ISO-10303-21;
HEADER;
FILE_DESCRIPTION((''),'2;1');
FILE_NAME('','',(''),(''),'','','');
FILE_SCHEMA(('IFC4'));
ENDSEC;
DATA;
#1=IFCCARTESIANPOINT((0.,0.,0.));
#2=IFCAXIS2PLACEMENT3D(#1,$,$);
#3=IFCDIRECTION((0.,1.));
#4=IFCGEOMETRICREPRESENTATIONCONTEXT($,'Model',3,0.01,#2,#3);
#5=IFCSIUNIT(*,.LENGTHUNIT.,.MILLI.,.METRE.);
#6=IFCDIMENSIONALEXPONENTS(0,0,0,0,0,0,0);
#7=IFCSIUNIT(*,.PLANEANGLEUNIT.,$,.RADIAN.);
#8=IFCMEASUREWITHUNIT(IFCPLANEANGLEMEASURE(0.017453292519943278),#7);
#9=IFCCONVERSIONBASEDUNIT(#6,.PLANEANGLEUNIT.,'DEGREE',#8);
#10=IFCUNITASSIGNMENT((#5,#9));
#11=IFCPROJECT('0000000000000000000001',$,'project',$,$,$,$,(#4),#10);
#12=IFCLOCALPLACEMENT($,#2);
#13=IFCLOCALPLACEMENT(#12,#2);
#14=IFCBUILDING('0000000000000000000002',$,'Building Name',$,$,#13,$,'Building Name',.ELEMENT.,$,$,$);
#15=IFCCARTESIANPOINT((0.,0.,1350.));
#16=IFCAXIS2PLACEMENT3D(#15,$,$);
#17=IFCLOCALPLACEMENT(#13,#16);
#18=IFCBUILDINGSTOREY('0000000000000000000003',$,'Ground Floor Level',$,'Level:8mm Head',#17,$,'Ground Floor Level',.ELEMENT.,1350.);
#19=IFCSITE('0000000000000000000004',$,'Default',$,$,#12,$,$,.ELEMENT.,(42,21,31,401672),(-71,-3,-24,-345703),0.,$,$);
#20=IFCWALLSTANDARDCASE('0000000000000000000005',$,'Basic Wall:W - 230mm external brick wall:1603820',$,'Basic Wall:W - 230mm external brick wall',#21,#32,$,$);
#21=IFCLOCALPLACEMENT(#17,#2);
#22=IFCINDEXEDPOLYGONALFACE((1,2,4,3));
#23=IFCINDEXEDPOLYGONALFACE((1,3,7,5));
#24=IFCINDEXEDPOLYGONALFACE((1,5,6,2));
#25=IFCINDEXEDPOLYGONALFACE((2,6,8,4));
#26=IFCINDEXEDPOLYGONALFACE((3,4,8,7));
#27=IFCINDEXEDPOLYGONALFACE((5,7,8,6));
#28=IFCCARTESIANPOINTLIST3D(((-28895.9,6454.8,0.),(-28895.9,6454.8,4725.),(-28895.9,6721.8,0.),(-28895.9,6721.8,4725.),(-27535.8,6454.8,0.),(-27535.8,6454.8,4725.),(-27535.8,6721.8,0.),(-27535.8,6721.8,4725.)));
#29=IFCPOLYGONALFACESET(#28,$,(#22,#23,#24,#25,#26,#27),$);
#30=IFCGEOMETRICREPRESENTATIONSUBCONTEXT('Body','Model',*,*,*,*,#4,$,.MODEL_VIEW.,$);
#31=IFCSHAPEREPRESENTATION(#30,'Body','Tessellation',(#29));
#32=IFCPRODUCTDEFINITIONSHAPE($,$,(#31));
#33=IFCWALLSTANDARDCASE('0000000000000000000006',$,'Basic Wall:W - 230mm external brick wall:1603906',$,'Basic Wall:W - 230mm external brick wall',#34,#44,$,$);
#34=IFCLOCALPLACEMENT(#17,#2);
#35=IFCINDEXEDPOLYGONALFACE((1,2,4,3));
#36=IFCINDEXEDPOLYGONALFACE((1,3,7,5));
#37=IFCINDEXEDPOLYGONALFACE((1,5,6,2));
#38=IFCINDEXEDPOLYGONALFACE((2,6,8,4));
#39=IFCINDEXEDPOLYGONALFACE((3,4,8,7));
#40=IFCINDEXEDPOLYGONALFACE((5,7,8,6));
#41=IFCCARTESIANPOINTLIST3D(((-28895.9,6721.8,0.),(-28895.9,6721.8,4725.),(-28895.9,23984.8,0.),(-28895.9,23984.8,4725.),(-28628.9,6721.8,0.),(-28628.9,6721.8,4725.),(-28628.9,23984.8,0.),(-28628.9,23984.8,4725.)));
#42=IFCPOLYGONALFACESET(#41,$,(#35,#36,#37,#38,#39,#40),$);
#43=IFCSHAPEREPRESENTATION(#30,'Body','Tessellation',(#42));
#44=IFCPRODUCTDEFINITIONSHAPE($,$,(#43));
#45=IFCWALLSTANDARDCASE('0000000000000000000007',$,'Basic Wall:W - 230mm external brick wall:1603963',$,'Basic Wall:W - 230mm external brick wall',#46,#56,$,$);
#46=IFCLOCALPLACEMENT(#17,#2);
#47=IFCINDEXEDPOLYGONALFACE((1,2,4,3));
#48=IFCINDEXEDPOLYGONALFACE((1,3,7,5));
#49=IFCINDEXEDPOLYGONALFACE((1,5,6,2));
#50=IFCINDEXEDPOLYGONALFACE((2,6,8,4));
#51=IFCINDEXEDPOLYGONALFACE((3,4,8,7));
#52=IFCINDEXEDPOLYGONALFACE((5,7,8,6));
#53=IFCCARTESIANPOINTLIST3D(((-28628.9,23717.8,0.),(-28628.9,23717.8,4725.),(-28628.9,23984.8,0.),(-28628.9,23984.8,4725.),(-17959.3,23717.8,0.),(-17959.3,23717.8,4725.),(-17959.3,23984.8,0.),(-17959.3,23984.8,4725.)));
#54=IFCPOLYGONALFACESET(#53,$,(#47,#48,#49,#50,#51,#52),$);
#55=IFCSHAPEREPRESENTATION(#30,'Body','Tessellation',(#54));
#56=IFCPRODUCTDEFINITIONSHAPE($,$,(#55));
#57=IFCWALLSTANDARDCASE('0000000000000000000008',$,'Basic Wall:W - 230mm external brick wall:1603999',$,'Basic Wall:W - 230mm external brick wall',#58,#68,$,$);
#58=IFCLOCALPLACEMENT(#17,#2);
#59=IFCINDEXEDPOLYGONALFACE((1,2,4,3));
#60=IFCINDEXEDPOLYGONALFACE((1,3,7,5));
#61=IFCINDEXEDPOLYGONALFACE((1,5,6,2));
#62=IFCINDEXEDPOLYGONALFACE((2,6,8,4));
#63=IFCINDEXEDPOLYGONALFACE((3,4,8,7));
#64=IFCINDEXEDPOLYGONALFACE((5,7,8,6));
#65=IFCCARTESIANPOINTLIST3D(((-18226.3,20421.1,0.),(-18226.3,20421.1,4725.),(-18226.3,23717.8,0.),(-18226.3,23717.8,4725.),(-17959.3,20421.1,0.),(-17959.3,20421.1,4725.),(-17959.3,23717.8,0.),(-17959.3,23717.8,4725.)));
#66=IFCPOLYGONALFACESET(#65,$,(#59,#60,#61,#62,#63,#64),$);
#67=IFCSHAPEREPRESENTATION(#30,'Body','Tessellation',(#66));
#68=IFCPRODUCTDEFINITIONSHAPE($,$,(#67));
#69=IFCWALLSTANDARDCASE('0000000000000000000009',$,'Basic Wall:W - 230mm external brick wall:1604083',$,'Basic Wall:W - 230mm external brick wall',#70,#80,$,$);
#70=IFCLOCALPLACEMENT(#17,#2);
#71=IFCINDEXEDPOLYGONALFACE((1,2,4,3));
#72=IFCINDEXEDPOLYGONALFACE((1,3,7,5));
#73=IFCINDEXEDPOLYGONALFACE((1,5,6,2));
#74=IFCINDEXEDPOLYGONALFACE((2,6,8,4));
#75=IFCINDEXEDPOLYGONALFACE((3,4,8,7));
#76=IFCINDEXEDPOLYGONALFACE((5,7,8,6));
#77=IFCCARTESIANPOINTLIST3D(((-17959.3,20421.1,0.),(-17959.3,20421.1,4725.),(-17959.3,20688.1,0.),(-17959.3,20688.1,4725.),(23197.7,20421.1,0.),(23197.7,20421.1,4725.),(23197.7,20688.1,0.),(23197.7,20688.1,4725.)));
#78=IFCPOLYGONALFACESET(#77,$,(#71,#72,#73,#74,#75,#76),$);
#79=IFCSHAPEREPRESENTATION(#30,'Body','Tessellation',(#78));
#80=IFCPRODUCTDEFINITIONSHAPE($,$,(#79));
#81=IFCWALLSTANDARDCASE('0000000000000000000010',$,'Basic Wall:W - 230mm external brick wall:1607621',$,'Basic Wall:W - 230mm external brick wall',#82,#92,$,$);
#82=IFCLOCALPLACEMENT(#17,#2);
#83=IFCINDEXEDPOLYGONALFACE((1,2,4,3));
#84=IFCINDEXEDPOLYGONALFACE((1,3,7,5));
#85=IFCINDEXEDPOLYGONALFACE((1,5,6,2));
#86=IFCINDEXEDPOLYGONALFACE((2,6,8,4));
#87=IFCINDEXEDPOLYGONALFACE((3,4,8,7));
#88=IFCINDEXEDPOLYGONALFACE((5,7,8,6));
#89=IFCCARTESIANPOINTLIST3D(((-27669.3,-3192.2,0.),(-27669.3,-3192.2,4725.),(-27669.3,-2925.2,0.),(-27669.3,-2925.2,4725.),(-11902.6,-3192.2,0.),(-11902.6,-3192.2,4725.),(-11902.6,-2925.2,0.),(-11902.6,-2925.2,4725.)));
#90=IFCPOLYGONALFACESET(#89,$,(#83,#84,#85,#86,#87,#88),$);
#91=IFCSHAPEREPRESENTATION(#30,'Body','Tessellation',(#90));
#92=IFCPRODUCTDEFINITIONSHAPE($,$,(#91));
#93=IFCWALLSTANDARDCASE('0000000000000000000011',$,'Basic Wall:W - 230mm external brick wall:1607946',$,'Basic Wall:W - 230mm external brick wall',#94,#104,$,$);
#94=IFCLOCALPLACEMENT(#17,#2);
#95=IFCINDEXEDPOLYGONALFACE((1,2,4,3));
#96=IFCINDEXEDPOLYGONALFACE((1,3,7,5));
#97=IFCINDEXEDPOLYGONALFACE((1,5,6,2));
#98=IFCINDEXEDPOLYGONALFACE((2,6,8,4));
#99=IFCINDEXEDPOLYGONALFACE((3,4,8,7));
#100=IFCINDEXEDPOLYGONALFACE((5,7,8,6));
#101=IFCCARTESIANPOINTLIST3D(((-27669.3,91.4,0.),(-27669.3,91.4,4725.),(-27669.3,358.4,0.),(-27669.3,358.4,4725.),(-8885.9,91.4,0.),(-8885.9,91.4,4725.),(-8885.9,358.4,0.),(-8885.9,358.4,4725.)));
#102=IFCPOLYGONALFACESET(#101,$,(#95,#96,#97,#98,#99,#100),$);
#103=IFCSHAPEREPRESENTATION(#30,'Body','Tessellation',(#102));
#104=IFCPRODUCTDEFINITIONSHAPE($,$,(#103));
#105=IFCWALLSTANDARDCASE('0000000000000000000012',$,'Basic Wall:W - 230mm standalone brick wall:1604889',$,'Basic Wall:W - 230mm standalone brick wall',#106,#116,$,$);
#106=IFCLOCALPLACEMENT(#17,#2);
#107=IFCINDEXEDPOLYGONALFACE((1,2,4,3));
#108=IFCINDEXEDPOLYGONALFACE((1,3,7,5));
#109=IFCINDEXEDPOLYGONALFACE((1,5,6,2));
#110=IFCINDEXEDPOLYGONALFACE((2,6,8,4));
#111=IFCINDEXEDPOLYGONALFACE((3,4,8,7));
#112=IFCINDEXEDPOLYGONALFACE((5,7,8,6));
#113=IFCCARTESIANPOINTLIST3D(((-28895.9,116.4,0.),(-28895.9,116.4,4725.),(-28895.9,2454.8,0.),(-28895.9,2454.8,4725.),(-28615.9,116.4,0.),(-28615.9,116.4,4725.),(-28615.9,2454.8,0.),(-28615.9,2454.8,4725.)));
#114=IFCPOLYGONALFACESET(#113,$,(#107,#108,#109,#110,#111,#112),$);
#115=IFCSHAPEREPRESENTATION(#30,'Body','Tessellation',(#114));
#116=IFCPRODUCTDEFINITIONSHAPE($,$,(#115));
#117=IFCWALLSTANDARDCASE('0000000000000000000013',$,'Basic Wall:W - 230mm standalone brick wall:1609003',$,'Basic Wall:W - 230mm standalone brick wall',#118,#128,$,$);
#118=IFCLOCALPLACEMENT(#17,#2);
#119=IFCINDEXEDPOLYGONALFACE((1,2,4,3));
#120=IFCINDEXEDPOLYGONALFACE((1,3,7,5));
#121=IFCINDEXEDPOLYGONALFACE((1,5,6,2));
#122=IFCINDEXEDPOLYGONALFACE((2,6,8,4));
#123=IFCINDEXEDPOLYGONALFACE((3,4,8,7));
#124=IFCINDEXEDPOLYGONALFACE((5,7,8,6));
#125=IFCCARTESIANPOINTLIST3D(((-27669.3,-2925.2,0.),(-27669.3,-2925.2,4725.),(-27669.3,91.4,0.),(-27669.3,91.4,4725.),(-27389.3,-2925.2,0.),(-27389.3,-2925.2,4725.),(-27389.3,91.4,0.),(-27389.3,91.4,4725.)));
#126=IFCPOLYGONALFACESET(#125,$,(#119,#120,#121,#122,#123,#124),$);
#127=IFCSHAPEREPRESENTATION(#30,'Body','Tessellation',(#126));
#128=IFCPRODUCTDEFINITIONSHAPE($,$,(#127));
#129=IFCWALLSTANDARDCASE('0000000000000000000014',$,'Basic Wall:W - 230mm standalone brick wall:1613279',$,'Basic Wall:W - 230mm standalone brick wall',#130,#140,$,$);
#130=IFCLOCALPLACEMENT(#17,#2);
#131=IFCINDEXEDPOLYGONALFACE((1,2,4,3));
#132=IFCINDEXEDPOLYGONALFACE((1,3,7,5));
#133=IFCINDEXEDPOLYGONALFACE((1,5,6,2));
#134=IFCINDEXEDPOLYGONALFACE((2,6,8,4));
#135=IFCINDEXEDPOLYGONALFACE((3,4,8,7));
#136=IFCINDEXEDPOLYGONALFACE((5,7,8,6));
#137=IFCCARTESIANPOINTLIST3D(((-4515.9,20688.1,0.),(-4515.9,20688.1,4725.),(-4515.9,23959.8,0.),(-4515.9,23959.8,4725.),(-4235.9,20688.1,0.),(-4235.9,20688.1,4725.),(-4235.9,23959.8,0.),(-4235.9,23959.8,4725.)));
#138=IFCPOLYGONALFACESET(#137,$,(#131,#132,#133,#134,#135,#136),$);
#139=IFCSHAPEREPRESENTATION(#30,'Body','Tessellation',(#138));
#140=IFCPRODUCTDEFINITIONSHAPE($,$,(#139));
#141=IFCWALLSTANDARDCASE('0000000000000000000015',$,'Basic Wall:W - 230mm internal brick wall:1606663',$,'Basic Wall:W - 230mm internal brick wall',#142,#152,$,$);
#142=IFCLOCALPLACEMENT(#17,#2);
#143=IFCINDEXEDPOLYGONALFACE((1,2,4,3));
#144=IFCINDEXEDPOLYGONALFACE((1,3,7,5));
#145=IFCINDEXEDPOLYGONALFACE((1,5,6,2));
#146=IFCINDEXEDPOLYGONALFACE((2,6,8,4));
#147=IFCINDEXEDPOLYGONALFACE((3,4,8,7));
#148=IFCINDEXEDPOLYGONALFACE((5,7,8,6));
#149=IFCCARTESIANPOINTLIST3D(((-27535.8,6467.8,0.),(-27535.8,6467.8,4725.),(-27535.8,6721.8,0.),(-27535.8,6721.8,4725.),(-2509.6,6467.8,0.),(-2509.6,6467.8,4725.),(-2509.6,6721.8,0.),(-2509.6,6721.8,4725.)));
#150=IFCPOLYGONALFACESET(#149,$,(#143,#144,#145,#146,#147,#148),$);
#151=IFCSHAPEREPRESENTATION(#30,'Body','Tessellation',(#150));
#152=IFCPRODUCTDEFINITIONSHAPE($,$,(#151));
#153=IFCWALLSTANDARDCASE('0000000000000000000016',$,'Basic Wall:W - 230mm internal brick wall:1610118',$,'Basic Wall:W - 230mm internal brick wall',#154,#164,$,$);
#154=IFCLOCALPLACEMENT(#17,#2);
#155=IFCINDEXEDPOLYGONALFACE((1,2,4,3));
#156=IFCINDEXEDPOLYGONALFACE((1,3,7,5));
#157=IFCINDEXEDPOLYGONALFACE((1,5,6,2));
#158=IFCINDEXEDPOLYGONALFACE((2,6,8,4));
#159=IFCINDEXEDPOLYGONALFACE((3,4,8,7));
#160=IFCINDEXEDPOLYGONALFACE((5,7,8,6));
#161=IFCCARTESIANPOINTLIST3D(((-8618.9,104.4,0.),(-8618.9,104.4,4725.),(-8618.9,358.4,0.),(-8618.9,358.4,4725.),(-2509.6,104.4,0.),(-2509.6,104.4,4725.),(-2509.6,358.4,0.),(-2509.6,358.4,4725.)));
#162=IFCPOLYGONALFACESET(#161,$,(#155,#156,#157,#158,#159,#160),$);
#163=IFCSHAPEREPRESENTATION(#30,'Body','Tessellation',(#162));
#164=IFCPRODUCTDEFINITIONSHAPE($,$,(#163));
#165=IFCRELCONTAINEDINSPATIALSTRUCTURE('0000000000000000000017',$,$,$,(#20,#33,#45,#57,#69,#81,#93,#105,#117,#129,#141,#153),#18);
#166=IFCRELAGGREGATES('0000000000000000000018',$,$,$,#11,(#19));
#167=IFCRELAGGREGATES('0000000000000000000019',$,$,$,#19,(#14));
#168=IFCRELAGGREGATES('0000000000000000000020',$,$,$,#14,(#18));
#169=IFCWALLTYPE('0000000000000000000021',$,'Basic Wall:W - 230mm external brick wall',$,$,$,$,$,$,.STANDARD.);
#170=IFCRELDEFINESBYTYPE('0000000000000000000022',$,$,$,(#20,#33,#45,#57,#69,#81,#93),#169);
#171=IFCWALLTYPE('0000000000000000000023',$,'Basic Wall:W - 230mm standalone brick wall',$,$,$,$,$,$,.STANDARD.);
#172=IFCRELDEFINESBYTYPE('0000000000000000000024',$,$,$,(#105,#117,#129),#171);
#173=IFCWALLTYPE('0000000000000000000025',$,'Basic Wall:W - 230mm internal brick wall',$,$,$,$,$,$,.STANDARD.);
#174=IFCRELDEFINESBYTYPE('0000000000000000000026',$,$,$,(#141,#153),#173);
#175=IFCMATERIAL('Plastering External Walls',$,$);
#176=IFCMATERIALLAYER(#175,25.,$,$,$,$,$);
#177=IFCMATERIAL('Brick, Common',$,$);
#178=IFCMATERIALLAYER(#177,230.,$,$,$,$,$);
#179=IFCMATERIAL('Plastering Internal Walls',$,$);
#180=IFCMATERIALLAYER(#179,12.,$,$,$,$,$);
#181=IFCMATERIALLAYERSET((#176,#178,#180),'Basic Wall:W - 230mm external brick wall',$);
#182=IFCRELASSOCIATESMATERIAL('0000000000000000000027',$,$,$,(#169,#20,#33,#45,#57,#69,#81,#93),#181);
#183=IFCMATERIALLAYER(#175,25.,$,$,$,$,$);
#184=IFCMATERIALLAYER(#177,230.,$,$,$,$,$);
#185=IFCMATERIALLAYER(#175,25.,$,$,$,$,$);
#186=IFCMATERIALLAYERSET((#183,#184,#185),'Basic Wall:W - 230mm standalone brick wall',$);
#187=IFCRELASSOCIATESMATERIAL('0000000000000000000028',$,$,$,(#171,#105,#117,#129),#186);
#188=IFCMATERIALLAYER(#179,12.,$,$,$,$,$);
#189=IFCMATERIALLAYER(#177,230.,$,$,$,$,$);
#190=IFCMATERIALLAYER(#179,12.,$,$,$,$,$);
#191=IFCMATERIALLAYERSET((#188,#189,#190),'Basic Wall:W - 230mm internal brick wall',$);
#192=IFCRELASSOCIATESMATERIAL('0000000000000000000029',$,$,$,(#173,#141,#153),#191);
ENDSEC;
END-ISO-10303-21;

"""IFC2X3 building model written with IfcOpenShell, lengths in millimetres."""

from ifc_helpers import new_model, entity, si_unit, converted_unit, direction, frame, frame_2d, origin, place, context, subcontext, project, spatial, rectangle, extrude, material, layer, layer_set, layer_usage, type_object, element, save


model = new_model("IFC2X3")

# Units and contexts
model_context = context("Model", 3, precision=0.01, world=origin(), true_north=direction((0.0, 1.0)))
body_context = subcontext(model_context, "Body", "Model", "MODEL_VIEW")
ifc_project = project(units=[si_unit("LENGTHUNIT", "METRE", prefix="MILLI"), converted_unit("PLANEANGLEUNIT", "DEGREE", entity("IfcPlaneAngleMeasure", 0.017453292519943278), si_unit("PLANEANGLEUNIT", "RADIAN"), dimensions=[0, 0, 0, 0, 0, 0, 0])], contexts=[model_context])

# Site, building, storey
site_placement = place(None, origin())
site = spatial("IfcSite", under=ifc_project, at=site_placement, Name="Default", CompositionType="ELEMENT", RefLatitude=(42, 21, 31, 401672), RefLongitude=(-71, -3, -24, -345703), RefElevation=0.0)
building_placement = place(site_placement, origin())
building = spatial("IfcBuilding", under=site, at=building_placement, Name="Building Name", LongName="Building Name", CompositionType="ELEMENT")
storey_placement = place(building_placement, frame((0.0, 0.0, 1350.0)))
storey = spatial("IfcBuildingStorey", under=building, at=storey_placement, Name="Ground Floor Level", ObjectType="Level:8mm Head", LongName="Ground Floor Level", CompositionType="ELEMENT", Elevation=1350.0)

# Walls
ifc_material_1 = material(Name="Plastering External Walls")
ifc_layer_1 = layer(ifc_material_1, 25.0)
ifc_material_2 = material(Name="Brick, Common")
ifc_layer_2 = layer(ifc_material_2, 230.0)
ifc_material_3 = material(Name="Plastering Internal Walls")
ifc_layer_3 = layer(ifc_material_3, 12.0)
ifc_layer_set_1 = layer_set([ifc_layer_1, ifc_layer_2, ifc_layer_3], Name="Basic Wall:W - 230mm external brick wall")
ifc_layer_usage_1 = layer_usage(ifc_layer_set_1, "AXIS2", "NEGATIVE", 133.5)
wall_type_1 = type_object("IfcWallType", Name="Basic Wall:W - 230mm external brick wall", PredefinedType="STANDARD", material=ifc_layer_set_1)
wall_1_placement = place(storey_placement, frame((-27535.8, 6588.3, 0.0), z_axis=(0.0, 0.0, 1.0), x_axis=(-1.0, 0.0, 0.0)))
element("IfcWallStandardCase", 1, at=wall_1_placement, inside=storey, type_object=wall_type_1, material=ifc_layer_usage_1, Name="Basic Wall:W - 230mm external brick wall:1603820", ObjectType="Basic Wall:W - 230mm external brick wall", context=body_context, shape_type="SweptSolid", body=[
    extrude(rectangle(XDim=1360.2, YDim=267.0, at=frame_2d((680.1, 0.0), x_axis=(-1.0, 0.0))), origin(), (0.0, 0.0, 1.0), 4725.0),
])
ifc_layer_usage_2 = layer_usage(ifc_layer_set_1, "AXIS2", "NEGATIVE", 133.5)
wall_2_placement = place(storey_placement, frame((-28762.4, 6721.8, 0.0), z_axis=(0.0, 0.0, 1.0), x_axis=(0.0, 1.0, 0.0)))
element("IfcWallStandardCase", 2, at=wall_2_placement, inside=storey, type_object=wall_type_1, material=ifc_layer_usage_2, Name="Basic Wall:W - 230mm external brick wall:1603906", ObjectType="Basic Wall:W - 230mm external brick wall", context=body_context, shape_type="SweptSolid", body=[
    extrude(rectangle(XDim=17263.0, YDim=267.0, at=frame_2d((8631.5, 0.0), x_axis=(-1.0, 0.0))), origin(), (0.0, 0.0, 1.0), 4725.0),
])
ifc_layer_usage_3 = layer_usage(ifc_layer_set_1, "AXIS2", "NEGATIVE", 133.5)
wall_3_placement = place(storey_placement, frame((-28628.9, 23851.3, 0.0)))
element("IfcWallStandardCase", 3, at=wall_3_placement, inside=storey, type_object=wall_type_1, material=ifc_layer_usage_3, Name="Basic Wall:W - 230mm external brick wall:1603963", ObjectType="Basic Wall:W - 230mm external brick wall", context=body_context, shape_type="SweptSolid", body=[
    extrude(rectangle(XDim=10669.7, YDim=267.0, at=frame_2d((5334.8, 0.0), x_axis=(-1.0, 0.0))), origin(), (0.0, 0.0, 1.0), 4725.0),
])
ifc_layer_usage_4 = layer_usage(ifc_layer_set_1, "AXIS2", "NEGATIVE", 133.5)
wall_4_placement = place(storey_placement, frame((-18092.8, 23717.8, 0.0), z_axis=(0.0, 0.0, 1.0), x_axis=(0.0, -1.0, 0.0)))
element("IfcWallStandardCase", 4, at=wall_4_placement, inside=storey, type_object=wall_type_1, material=ifc_layer_usage_4, Name="Basic Wall:W - 230mm external brick wall:1603999", ObjectType="Basic Wall:W - 230mm external brick wall", context=body_context, shape_type="SweptSolid", body=[
    extrude(rectangle(XDim=3296.7, YDim=267.0, at=frame_2d((1648.3, 0.0), x_axis=(-1.0, 0.0))), origin(), (0.0, 0.0, 1.0), 4725.0),
])
ifc_layer_usage_5 = layer_usage(ifc_layer_set_1, "AXIS2", "NEGATIVE", 133.5)
wall_5_placement = place(storey_placement, frame((-17959.3, 20554.6, 0.0)))
element("IfcWallStandardCase", 5, at=wall_5_placement, inside=storey, type_object=wall_type_1, material=ifc_layer_usage_5, Name="Basic Wall:W - 230mm external brick wall:1604083", ObjectType="Basic Wall:W - 230mm external brick wall", context=body_context, shape_type="SweptSolid", body=[
    extrude(rectangle(XDim=41157.0, YDim=267.0, at=frame_2d((20578.5, 0.0), x_axis=(-1.0, 0.0))), origin(), (0.0, 0.0, 1.0), 4725.0),
])
ifc_layer_usage_6 = layer_usage(ifc_layer_set_1, "AXIS2", "NEGATIVE", 133.5)
wall_6_placement = place(storey_placement, frame((-27669.3, -3058.7, 0.0)))
element("IfcWallStandardCase", 6, at=wall_6_placement, inside=storey, type_object=wall_type_1, material=ifc_layer_usage_6, Name="Basic Wall:W - 230mm external brick wall:1607621", ObjectType="Basic Wall:W - 230mm external brick wall", context=body_context, shape_type="SweptSolid", body=[
    extrude(rectangle(XDim=15766.7, YDim=267.0, at=frame_2d((7883.3, 0.0), x_axis=(-1.0, 0.0))), origin(), (0.0, 0.0, 1.0), 4725.0),
])
ifc_layer_usage_7 = layer_usage(ifc_layer_set_1, "AXIS2", "NEGATIVE", 133.5)
wall_7_placement = place(storey_placement, frame((-8885.9, 224.9, 0.0), z_axis=(0.0, 0.0, 1.0), x_axis=(-1.0, 0.0, 0.0)))
element("IfcWallStandardCase", 7, at=wall_7_placement, inside=storey, type_object=wall_type_1, material=ifc_layer_usage_7, Name="Basic Wall:W - 230mm external brick wall:1607946", ObjectType="Basic Wall:W - 230mm external brick wall", context=body_context, shape_type="SweptSolid", body=[
    extrude(rectangle(XDim=18783.3, YDim=267.0, at=frame_2d((9391.7, 0.0), x_axis=(-1.0, 0.0))), origin(), (0.0, 0.0, 1.0), 4725.0),
])
ifc_layer_4 = layer(ifc_material_1, 25.0)
ifc_layer_5 = layer(ifc_material_2, 230.0)
ifc_layer_6 = layer(ifc_material_1, 25.0)
ifc_layer_set_2 = layer_set([ifc_layer_4, ifc_layer_5, ifc_layer_6], Name="Basic Wall:W - 230mm standalone brick wall")
ifc_layer_usage_8 = layer_usage(ifc_layer_set_2, "AXIS2", "NEGATIVE", 140.0)
wall_type_2 = type_object("IfcWallType", Name="Basic Wall:W - 230mm standalone brick wall", PredefinedType="STANDARD", material=ifc_layer_set_2)
wall_8_placement = place(storey_placement, frame((-28755.9, 116.4, 0.0), z_axis=(0.0, 0.0, 1.0), x_axis=(0.0, 1.0, 0.0)))
element("IfcWallStandardCase", 8, at=wall_8_placement, inside=storey, type_object=wall_type_2, material=ifc_layer_usage_8, Name="Basic Wall:W - 230mm standalone brick wall:1604889", ObjectType="Basic Wall:W - 230mm standalone brick wall", context=body_context, shape_type="SweptSolid", body=[
    extrude(rectangle(XDim=2338.3, YDim=280.0, at=frame_2d((1169.2, 0.0), x_axis=(-1.0, 0.0))), origin(), (0.0, 0.0, 1.0), 4725.0),
])
ifc_layer_usage_9 = layer_usage(ifc_layer_set_2, "AXIS2", "NEGATIVE", 140.0)
wall_9_placement = place(storey_placement, frame((-27529.3, -2925.2, 0.0), z_axis=(0.0, 0.0, 1.0), x_axis=(0.0, 1.0, 0.0)))
element("IfcWallStandardCase", 9, at=wall_9_placement, inside=storey, type_object=wall_type_2, material=ifc_layer_usage_9, Name="Basic Wall:W - 230mm standalone brick wall:1609003", ObjectType="Basic Wall:W - 230mm standalone brick wall", context=body_context, shape_type="SweptSolid", body=[
    extrude(rectangle(XDim=3016.7, YDim=280.0, at=frame_2d((1508.3, 0.0), x_axis=(-1.0, 0.0))), origin(), (0.0, 0.0, 1.0), 4725.0),
])
ifc_layer_usage_10 = layer_usage(ifc_layer_set_2, "AXIS2", "NEGATIVE", 140.0)
wall_10_placement = place(storey_placement, frame((-4375.9, 20688.1, 0.0), z_axis=(0.0, 0.0, 1.0), x_axis=(0.0, 1.0, 0.0)))
element("IfcWallStandardCase", 10, at=wall_10_placement, inside=storey, type_object=wall_type_2, material=ifc_layer_usage_10, Name="Basic Wall:W - 230mm standalone brick wall:1613279", ObjectType="Basic Wall:W - 230mm standalone brick wall", context=body_context, shape_type="SweptSolid", body=[
    extrude(rectangle(XDim=3271.7, YDim=280.0, at=frame_2d((1635.8, 0.0), x_axis=(-1.0, 0.0))), origin(), (0.0, 0.0, 1.0), 4725.0),
])
ifc_layer_7 = layer(ifc_material_3, 12.0)
ifc_layer_8 = layer(ifc_material_2, 230.0)
ifc_layer_9 = layer(ifc_material_3, 12.0)
ifc_layer_set_3 = layer_set([ifc_layer_7, ifc_layer_8, ifc_layer_9], Name="Basic Wall:W - 230mm internal brick wall")
ifc_layer_usage_11 = layer_usage(ifc_layer_set_3, "AXIS2", "NEGATIVE", 127.0)
wall_type_3 = type_object("IfcWallType", Name="Basic Wall:W - 230mm internal brick wall", PredefinedType="STANDARD", material=ifc_layer_set_3)
wall_11_placement = place(storey_placement, frame((-2509.6, 6594.8, 0.0), z_axis=(0.0, 0.0, 1.0), x_axis=(-1.0, 0.0, 0.0)))
element("IfcWallStandardCase", 11, at=wall_11_placement, inside=storey, type_object=wall_type_3, material=ifc_layer_usage_11, Name="Basic Wall:W - 230mm internal brick wall:1606663", ObjectType="Basic Wall:W - 230mm internal brick wall", context=body_context, shape_type="SweptSolid", body=[
    extrude(rectangle(XDim=25026.2, YDim=254.0, at=frame_2d((12513.1, 0.0), x_axis=(-1.0, 0.0))), origin(), (0.0, 0.0, 1.0), 4725.0),
])
ifc_layer_usage_12 = layer_usage(ifc_layer_set_3, "AXIS2", "NEGATIVE", 127.0)
wall_12_placement = place(storey_placement, frame((-2509.6, 231.4, 0.0), z_axis=(0.0, 0.0, 1.0), x_axis=(-1.0, 0.0, 0.0)))
element("IfcWallStandardCase", 12, at=wall_12_placement, inside=storey, type_object=wall_type_3, material=ifc_layer_usage_12, Name="Basic Wall:W - 230mm internal brick wall:1610118", ObjectType="Basic Wall:W - 230mm internal brick wall", context=body_context, shape_type="SweptSolid", body=[
    extrude(rectangle(XDim=6109.3, YDim=254.0, at=frame_2d((3054.7, 0.0), x_axis=(-1.0, 0.0))), origin(), (0.0, 0.0, 1.0), 4725.0),
])

save(model, "model.ifc")
